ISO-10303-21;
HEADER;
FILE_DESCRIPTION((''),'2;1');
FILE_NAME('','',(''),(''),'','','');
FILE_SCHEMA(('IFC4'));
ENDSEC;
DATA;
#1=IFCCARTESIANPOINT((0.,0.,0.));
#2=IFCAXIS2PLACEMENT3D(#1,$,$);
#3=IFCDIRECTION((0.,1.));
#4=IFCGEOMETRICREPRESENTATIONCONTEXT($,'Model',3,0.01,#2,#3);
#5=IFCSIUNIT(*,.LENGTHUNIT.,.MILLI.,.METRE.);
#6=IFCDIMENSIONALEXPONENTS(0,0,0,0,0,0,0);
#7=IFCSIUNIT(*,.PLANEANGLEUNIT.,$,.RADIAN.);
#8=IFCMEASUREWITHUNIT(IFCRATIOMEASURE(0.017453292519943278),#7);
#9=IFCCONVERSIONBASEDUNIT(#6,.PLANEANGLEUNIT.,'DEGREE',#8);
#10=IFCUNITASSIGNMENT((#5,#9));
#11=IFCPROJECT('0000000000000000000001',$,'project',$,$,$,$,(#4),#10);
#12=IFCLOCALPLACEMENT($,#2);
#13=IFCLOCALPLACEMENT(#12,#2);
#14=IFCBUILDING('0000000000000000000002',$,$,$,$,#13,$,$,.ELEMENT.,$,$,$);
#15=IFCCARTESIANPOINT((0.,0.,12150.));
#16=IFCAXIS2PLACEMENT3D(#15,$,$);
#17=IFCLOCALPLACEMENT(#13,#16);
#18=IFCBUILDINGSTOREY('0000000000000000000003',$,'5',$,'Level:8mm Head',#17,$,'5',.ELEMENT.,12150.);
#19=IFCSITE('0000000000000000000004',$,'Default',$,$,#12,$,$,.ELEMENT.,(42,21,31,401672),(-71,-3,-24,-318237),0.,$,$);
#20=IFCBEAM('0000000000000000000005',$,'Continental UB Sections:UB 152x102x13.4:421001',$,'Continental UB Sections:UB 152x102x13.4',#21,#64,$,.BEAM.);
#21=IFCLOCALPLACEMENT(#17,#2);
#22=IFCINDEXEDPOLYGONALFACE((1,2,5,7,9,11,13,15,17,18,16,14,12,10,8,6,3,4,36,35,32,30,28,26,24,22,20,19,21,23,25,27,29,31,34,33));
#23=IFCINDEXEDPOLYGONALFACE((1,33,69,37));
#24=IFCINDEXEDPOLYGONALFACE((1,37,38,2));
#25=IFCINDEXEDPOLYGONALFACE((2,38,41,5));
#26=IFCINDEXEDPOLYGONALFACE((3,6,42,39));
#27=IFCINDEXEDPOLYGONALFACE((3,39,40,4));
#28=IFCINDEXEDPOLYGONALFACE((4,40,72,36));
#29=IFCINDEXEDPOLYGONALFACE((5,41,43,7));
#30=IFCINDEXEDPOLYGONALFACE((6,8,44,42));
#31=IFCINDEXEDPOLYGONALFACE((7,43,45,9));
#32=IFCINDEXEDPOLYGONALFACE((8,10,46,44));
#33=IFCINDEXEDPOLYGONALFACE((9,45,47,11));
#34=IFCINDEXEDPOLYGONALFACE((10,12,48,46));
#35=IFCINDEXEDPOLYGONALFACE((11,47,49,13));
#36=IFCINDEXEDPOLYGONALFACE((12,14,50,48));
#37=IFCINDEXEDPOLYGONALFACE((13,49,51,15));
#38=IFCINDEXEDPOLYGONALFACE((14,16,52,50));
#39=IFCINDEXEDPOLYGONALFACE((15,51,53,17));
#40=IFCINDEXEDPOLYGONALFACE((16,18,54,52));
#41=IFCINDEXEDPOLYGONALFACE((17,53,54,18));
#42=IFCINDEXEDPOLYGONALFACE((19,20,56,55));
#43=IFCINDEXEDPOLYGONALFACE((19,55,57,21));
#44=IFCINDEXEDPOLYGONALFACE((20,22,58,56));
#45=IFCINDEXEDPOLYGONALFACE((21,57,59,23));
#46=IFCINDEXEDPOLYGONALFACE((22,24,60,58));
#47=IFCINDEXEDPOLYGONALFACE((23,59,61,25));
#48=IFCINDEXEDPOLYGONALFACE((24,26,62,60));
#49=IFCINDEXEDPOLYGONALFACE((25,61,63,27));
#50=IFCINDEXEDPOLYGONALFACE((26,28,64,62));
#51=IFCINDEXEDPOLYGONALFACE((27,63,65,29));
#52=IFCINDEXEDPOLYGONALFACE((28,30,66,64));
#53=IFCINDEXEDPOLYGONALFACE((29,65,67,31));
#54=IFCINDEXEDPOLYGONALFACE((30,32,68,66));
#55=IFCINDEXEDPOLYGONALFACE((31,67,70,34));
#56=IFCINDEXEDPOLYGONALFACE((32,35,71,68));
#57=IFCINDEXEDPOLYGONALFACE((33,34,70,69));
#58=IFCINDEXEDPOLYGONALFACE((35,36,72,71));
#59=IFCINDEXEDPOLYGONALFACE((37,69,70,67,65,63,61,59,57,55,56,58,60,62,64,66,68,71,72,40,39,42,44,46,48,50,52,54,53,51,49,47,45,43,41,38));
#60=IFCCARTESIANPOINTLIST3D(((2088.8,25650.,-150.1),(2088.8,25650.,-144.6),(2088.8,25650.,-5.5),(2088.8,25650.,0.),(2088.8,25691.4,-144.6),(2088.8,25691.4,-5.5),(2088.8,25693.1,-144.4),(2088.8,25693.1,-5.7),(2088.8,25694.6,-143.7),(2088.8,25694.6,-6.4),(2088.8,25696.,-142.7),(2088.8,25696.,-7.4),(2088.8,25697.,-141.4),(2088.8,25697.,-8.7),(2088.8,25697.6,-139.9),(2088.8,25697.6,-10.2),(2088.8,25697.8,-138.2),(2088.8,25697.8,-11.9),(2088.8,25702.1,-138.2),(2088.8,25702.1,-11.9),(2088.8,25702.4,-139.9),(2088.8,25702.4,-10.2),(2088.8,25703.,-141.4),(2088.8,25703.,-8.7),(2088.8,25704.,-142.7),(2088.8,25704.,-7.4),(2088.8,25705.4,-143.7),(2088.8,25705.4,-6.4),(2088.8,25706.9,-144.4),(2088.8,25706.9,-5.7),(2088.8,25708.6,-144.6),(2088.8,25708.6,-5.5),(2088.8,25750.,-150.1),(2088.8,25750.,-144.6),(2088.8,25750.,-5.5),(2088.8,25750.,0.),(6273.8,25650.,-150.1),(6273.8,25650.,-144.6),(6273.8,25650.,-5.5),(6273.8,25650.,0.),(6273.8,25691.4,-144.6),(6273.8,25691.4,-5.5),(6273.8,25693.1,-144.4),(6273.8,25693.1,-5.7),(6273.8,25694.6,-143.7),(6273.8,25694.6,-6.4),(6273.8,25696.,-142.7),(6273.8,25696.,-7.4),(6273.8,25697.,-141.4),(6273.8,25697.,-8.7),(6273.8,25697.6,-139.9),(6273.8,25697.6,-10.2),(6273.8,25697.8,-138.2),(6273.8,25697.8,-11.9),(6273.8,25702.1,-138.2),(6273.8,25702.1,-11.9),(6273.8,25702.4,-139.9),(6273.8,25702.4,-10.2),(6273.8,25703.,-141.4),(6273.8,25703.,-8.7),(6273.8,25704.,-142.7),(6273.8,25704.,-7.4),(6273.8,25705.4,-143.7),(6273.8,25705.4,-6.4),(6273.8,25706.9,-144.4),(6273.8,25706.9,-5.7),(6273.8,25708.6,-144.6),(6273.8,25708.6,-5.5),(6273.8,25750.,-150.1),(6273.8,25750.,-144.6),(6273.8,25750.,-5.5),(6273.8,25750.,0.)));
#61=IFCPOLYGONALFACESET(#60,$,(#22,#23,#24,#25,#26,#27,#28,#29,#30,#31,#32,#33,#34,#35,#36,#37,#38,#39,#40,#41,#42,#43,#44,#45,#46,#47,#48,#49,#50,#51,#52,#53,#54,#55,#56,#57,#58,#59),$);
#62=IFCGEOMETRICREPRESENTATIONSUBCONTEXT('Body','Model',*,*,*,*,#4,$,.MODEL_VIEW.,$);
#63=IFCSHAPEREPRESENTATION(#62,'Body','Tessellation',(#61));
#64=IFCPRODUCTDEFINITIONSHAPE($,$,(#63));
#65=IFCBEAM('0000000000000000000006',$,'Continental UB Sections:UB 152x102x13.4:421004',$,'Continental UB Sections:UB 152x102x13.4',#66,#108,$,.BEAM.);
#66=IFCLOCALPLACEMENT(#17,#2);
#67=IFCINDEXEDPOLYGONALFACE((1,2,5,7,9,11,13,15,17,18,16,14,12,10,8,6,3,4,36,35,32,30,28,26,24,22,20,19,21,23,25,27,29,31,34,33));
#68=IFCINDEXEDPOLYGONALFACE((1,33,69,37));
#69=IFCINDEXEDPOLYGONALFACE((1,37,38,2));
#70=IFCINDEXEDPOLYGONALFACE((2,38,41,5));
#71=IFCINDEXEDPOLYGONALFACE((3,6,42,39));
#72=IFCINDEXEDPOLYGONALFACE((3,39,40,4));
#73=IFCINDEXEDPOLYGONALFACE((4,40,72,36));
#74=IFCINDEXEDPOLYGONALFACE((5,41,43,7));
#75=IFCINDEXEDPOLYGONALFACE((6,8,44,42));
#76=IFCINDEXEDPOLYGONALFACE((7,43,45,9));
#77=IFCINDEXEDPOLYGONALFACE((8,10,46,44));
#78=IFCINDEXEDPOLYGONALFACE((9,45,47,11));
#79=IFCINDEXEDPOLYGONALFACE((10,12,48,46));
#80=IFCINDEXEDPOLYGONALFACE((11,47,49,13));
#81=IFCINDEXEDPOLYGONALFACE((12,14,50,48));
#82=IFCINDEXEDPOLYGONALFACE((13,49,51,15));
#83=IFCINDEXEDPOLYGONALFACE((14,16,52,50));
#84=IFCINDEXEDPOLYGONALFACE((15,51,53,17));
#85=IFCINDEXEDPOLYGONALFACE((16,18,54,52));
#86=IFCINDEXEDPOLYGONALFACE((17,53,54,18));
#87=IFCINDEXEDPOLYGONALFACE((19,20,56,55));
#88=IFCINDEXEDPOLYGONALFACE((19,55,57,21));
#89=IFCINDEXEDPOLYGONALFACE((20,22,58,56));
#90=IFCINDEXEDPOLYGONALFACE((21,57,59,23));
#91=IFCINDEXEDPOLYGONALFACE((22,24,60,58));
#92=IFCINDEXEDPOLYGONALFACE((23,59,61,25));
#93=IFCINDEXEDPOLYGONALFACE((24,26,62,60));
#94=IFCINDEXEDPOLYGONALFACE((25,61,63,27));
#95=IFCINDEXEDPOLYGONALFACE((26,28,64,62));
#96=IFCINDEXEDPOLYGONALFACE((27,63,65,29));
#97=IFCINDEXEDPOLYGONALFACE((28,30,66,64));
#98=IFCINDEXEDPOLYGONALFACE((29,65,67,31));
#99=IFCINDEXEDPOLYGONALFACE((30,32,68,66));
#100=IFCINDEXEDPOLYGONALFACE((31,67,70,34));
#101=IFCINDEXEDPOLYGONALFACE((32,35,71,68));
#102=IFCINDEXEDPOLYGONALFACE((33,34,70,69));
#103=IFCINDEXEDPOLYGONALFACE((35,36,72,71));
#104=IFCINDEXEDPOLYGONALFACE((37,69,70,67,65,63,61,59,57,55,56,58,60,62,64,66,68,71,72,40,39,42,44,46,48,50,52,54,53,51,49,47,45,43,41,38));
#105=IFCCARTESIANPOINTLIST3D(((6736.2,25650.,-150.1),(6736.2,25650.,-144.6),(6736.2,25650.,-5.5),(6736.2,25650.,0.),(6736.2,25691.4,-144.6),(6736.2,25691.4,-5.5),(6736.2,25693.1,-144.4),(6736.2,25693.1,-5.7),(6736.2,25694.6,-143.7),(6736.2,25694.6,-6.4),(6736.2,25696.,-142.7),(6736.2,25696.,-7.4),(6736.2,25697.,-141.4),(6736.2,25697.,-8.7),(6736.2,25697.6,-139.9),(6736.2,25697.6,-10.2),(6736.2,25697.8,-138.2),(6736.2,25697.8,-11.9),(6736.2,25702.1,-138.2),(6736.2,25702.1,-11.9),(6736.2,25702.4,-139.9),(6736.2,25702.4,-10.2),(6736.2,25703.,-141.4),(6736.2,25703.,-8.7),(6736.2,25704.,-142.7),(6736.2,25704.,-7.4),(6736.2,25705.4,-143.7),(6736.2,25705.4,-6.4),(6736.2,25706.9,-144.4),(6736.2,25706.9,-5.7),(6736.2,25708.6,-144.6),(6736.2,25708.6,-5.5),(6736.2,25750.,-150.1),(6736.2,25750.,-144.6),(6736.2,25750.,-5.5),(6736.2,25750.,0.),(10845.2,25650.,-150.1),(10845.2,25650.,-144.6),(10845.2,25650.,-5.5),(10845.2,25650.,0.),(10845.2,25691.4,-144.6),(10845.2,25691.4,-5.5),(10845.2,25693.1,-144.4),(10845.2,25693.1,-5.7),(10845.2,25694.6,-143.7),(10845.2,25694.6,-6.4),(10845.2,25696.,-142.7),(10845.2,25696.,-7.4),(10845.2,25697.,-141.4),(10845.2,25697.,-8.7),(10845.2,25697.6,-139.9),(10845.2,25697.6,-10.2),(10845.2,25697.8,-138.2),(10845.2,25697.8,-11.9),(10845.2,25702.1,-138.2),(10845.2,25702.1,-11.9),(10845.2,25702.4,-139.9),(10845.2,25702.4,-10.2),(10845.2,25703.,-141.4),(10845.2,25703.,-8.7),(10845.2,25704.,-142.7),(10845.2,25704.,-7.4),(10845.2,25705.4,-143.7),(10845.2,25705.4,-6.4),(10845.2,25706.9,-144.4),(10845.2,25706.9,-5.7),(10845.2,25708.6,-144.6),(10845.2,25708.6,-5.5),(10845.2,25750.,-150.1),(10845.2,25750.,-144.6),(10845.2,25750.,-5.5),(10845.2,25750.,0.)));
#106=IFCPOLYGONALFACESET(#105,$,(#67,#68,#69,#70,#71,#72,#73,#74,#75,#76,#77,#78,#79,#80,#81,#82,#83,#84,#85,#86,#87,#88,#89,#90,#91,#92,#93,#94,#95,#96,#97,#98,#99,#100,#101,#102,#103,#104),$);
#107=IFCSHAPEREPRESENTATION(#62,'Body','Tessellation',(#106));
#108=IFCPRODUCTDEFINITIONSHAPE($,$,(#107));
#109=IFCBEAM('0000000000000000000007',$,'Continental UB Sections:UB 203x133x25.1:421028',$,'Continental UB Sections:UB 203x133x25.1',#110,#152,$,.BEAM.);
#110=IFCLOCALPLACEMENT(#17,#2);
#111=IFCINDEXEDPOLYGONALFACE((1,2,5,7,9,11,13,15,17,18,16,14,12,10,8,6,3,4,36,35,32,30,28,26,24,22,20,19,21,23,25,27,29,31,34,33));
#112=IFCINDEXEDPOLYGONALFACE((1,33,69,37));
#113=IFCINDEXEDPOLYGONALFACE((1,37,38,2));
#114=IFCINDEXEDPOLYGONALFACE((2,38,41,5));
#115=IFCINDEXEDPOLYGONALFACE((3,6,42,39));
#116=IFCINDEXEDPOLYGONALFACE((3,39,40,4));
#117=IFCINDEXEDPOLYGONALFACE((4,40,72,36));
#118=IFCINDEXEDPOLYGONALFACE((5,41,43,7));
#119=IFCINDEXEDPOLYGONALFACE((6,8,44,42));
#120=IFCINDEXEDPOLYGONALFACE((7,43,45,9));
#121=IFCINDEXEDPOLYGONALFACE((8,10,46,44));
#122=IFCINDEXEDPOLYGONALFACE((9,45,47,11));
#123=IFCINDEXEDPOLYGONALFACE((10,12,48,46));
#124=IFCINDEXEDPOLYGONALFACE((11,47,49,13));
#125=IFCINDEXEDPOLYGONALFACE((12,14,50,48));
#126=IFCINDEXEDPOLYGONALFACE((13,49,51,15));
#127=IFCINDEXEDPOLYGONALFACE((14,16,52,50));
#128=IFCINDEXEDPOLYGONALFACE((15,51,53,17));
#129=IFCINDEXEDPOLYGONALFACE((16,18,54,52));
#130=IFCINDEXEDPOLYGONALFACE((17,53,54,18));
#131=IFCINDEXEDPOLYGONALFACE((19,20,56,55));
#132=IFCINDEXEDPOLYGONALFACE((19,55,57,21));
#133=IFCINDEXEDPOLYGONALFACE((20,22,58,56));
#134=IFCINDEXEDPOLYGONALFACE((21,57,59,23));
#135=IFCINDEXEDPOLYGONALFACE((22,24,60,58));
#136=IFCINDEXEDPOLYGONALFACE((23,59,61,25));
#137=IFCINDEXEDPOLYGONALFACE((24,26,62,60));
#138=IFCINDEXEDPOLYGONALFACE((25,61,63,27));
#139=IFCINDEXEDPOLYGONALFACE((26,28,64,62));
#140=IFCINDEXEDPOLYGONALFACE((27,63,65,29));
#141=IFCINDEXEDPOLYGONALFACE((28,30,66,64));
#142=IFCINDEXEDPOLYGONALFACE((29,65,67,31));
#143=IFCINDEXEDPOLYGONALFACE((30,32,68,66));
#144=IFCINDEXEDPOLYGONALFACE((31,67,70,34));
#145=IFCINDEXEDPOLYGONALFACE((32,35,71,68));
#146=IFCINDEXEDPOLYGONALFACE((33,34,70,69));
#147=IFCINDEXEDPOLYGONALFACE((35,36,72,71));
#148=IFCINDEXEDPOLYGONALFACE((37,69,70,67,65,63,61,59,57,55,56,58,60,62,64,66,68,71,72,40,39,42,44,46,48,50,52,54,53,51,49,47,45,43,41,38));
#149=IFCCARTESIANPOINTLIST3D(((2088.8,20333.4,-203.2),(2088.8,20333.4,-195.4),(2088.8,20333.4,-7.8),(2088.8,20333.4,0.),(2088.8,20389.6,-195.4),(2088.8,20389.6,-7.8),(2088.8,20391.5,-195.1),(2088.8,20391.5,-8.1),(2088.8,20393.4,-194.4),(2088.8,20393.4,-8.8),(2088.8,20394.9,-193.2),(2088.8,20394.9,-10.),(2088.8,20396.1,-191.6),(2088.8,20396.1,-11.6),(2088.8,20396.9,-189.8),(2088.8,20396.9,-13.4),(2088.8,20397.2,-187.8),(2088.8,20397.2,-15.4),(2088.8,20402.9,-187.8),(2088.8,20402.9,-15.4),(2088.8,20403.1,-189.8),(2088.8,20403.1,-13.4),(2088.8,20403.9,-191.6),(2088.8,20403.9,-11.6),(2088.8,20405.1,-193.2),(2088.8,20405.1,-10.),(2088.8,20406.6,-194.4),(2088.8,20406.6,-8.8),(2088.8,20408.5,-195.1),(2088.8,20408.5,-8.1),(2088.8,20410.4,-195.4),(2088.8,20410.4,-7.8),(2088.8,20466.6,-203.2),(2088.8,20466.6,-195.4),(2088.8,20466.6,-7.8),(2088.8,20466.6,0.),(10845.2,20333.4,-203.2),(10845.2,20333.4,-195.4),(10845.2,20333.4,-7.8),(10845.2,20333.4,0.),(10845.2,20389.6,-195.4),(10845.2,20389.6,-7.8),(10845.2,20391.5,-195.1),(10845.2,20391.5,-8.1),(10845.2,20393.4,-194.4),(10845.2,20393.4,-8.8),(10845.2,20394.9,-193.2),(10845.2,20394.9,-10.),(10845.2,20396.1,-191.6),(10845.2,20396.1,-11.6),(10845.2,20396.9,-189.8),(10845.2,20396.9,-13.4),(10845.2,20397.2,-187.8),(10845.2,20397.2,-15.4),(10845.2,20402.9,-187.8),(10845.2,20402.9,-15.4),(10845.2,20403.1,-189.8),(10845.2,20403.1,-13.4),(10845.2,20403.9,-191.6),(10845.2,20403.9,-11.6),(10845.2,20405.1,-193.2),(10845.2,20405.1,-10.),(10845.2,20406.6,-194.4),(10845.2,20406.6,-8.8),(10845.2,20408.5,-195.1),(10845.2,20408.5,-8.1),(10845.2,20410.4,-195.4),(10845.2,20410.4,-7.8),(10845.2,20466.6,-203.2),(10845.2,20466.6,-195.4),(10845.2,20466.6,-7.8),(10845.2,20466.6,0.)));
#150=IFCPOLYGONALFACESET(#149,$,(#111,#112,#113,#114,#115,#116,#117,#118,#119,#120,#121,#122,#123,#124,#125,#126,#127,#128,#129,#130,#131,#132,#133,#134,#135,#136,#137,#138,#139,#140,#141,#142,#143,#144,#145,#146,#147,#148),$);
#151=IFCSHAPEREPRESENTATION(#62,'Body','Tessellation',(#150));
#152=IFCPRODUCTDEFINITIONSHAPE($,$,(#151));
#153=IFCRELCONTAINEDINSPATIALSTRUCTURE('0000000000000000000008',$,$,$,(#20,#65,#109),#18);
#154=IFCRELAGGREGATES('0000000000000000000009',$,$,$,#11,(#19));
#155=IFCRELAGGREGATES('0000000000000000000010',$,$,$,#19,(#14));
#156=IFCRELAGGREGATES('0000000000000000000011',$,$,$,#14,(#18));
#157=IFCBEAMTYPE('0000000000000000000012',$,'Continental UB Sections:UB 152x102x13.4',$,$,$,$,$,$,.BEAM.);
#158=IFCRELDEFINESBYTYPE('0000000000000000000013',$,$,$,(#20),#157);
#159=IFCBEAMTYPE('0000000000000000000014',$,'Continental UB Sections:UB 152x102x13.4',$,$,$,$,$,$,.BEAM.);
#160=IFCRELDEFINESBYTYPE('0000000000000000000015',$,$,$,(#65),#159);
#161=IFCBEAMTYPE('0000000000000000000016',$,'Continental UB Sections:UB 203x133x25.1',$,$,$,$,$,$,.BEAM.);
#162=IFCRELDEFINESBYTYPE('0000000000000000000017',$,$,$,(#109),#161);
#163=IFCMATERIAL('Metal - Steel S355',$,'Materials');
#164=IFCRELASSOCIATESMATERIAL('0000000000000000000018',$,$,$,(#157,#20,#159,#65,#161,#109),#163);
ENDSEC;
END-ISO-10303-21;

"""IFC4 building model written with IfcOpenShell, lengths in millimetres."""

from ifc_helpers import new_model, entity, si_unit, converted_unit, direction, frame, origin, place, context, subcontext, project, spatial, line, arc, indexed_curve, outline, extrude, source, transform, mapped, material, type_object, type_shapes, element, save


model = new_model("IFC4")

# Units and contexts
model_context = context("Model", 3, precision=0.01, world=origin(), true_north=direction((0.0, 1.0)))
body_context = subcontext(model_context, "Body", "Model", "MODEL_VIEW")
ifc_project = project(units=[si_unit("LENGTHUNIT", "METRE", prefix="MILLI"), converted_unit("PLANEANGLEUNIT", "DEGREE", entity("IfcRatioMeasure", 0.017453292519943278), si_unit("PLANEANGLEUNIT", "RADIAN"), dimensions=[0, 0, 0, 0, 0, 0, 0])], contexts=[model_context])

# Site, building, storey
site_placement = place(None, origin())
site = spatial("IfcSite", under=ifc_project, at=site_placement, Name="Default", CompositionType="ELEMENT", RefLatitude=(42, 21, 31, 401672), RefLongitude=(-71, -3, -24, -318237), RefElevation=0.0)
building_placement = place(site_placement, origin())
building = spatial("IfcBuilding", under=site, at=building_placement, CompositionType="ELEMENT")
storey_placement = place(building_placement, frame((0.0, 0.0, 12150.0)))
storey = spatial("IfcBuildingStorey", under=building, at=storey_placement, Name="5", ObjectType="Level:8mm Head", LongName="5", CompositionType="ELEMENT", Elevation=12150.0)

# Beams
ifc_material = material(Name="Metal - Steel S355", Category="Materials")
beam_type_1 = type_object("IfcBeamType", Name="Continental UB Sections:UB 152x102x13.4", PredefinedType="BEAM", material=ifc_material)
shared_shape_1 = source(origin(), body_context, "Body", "SweptSolid", [
    extrude(outline(indexed_curve([(-75.0, -50.1), (-69.6, -50.1), (-69.6, -8.5), (-67.7, -4.0), (-63.2, -2.1), (63.1, -2.1), (67.7, -4.0), (69.5, -8.5), (69.5, -50.1), (75.1, -50.1), (75.1, 50.1), (69.5, 50.1), (69.5, 8.6), (67.7, 4.0), (63.1, 2.2), (-63.2, 2.2), (-67.7, 4.0), (-69.6, 8.6), (-69.6, 50.0), (-75.0, 50.0)], segments=[line(1, 2, 3), arc(3, 4, 5), line(5, 6), arc(6, 7, 8), line(8, 9, 10, 11, 12, 13), arc(13, 14, 15), line(15, 16), arc(16, 17, 18), line(18, 19, 20, 1)], self_intersect=False)), frame((-2163.7, 0.0, 0.0), z_axis=(1.0, 0.0, 0.0), x_axis=(0.0, 0.0, -1.0)), (0.0, 0.0, 1.0), 4185.0),
])
type_shapes(beam_type_1, [shared_shape_1])
beam_1_placement = place(storey_placement, frame((4252.5, 25700.0, -75.1)))
element("IfcBeam", 1, at=beam_1_placement, inside=storey, type_object=beam_type_1, material=ifc_material, Name="Continental UB Sections:UB 152x102x13.4:421001", ObjectType="Continental UB Sections:UB 152x102x13.4", PredefinedType="BEAM", context=body_context, shape_type="MappedRepresentation", body=[
    mapped(shared_shape_1, transform((0.0, 0.0, 0.0), scale=1.0)),
])
beam_type_2 = type_object("IfcBeamType", Name="Continental UB Sections:UB 152x102x13.4", PredefinedType="BEAM", material=ifc_material)
shared_shape_2 = source(origin(), body_context, "Body", "SweptSolid", [
    extrude(outline(indexed_curve([(-75.0, -50.1), (-69.6, -50.1), (-69.6, -8.5), (-67.7, -4.0), (-63.2, -2.1), (63.1, -2.1), (67.7, -4.0), (69.5, -8.5), (69.5, -50.1), (75.1, -50.1), (75.1, 50.1), (69.5, 50.1), (69.5, 8.6), (67.7, 4.0), (63.1, 2.2), (-63.2, 2.2), (-67.7, 4.0), (-69.6, 8.6), (-69.6, 50.0), (-75.0, 50.0)], segments=[line(1, 2, 3), arc(3, 4, 5), line(5, 6), arc(6, 7, 8), line(8, 9, 10, 11, 12, 13), arc(13, 14, 15), line(15, 16), arc(16, 17, 18), line(18, 19, 20, 1)], self_intersect=False)), frame((-2021.3, 0.0, 0.0), z_axis=(1.0, 0.0, 0.0), x_axis=(0.0, 0.0, -1.0)), (0.0, 0.0, 1.0), 4109.0),
])
type_shapes(beam_type_2, [shared_shape_2])
beam_2_placement = place(storey_placement, frame((8757.5, 25700.0, -75.1)))
element("IfcBeam", 2, at=beam_2_placement, inside=storey, type_object=beam_type_2, material=ifc_material, Name="Continental UB Sections:UB 152x102x13.4:421004", ObjectType="Continental UB Sections:UB 152x102x13.4", PredefinedType="BEAM", context=body_context, shape_type="MappedRepresentation", body=[
    mapped(shared_shape_2, transform((0.0, 0.0, 0.0), scale=1.0)),
])
beam_type_3 = type_object("IfcBeamType", Name="Continental UB Sections:UB 203x133x25.1", PredefinedType="BEAM", material=ifc_material)
shared_shape_3 = source(origin(), body_context, "Body", "SweptSolid", [
    extrude(outline(indexed_curve([(-101.6, -66.6), (-93.8, -66.6), (-93.8, -10.4), (-91.6, -5.1), (-86.2, -2.8), (86.2, -2.8), (91.6, -5.1), (93.8, -10.4), (93.8, -66.6), (101.6, -66.6), (101.6, 66.6), (93.8, 66.6), (93.8, 10.5), (91.6, 5.1), (86.2, 2.9), (-86.2, 2.9), (-91.6, 5.1), (-93.8, 10.5), (-93.8, 66.6), (-101.6, 66.6)], segments=[line(1, 2, 3), arc(3, 4, 5), line(5, 6), arc(6, 7, 8), line(8, 9, 10, 11, 12, 13), arc(13, 14, 15), line(15, 16), arc(16, 17, 18), line(18, 19, 20, 1)], self_intersect=False)), frame((-4416.2, 0.0, 0.0), z_axis=(1.0, 0.0, 0.0), x_axis=(0.0, 0.0, -1.0)), (0.0, 0.0, 1.0), 8756.4),
])
type_shapes(beam_type_3, [shared_shape_3])
beam_3_placement = place(storey_placement, frame((6505.0, 20400.0, -101.6)))
element("IfcBeam", 3, at=beam_3_placement, inside=storey, type_object=beam_type_3, material=ifc_material, Name="Continental UB Sections:UB 203x133x25.1:421028", ObjectType="Continental UB Sections:UB 203x133x25.1", PredefinedType="BEAM", context=body_context, shape_type="MappedRepresentation", body=[
    mapped(shared_shape_3, transform((0.0, 0.0, 0.0), scale=1.0)),
])

save(model, "model.ifc")
